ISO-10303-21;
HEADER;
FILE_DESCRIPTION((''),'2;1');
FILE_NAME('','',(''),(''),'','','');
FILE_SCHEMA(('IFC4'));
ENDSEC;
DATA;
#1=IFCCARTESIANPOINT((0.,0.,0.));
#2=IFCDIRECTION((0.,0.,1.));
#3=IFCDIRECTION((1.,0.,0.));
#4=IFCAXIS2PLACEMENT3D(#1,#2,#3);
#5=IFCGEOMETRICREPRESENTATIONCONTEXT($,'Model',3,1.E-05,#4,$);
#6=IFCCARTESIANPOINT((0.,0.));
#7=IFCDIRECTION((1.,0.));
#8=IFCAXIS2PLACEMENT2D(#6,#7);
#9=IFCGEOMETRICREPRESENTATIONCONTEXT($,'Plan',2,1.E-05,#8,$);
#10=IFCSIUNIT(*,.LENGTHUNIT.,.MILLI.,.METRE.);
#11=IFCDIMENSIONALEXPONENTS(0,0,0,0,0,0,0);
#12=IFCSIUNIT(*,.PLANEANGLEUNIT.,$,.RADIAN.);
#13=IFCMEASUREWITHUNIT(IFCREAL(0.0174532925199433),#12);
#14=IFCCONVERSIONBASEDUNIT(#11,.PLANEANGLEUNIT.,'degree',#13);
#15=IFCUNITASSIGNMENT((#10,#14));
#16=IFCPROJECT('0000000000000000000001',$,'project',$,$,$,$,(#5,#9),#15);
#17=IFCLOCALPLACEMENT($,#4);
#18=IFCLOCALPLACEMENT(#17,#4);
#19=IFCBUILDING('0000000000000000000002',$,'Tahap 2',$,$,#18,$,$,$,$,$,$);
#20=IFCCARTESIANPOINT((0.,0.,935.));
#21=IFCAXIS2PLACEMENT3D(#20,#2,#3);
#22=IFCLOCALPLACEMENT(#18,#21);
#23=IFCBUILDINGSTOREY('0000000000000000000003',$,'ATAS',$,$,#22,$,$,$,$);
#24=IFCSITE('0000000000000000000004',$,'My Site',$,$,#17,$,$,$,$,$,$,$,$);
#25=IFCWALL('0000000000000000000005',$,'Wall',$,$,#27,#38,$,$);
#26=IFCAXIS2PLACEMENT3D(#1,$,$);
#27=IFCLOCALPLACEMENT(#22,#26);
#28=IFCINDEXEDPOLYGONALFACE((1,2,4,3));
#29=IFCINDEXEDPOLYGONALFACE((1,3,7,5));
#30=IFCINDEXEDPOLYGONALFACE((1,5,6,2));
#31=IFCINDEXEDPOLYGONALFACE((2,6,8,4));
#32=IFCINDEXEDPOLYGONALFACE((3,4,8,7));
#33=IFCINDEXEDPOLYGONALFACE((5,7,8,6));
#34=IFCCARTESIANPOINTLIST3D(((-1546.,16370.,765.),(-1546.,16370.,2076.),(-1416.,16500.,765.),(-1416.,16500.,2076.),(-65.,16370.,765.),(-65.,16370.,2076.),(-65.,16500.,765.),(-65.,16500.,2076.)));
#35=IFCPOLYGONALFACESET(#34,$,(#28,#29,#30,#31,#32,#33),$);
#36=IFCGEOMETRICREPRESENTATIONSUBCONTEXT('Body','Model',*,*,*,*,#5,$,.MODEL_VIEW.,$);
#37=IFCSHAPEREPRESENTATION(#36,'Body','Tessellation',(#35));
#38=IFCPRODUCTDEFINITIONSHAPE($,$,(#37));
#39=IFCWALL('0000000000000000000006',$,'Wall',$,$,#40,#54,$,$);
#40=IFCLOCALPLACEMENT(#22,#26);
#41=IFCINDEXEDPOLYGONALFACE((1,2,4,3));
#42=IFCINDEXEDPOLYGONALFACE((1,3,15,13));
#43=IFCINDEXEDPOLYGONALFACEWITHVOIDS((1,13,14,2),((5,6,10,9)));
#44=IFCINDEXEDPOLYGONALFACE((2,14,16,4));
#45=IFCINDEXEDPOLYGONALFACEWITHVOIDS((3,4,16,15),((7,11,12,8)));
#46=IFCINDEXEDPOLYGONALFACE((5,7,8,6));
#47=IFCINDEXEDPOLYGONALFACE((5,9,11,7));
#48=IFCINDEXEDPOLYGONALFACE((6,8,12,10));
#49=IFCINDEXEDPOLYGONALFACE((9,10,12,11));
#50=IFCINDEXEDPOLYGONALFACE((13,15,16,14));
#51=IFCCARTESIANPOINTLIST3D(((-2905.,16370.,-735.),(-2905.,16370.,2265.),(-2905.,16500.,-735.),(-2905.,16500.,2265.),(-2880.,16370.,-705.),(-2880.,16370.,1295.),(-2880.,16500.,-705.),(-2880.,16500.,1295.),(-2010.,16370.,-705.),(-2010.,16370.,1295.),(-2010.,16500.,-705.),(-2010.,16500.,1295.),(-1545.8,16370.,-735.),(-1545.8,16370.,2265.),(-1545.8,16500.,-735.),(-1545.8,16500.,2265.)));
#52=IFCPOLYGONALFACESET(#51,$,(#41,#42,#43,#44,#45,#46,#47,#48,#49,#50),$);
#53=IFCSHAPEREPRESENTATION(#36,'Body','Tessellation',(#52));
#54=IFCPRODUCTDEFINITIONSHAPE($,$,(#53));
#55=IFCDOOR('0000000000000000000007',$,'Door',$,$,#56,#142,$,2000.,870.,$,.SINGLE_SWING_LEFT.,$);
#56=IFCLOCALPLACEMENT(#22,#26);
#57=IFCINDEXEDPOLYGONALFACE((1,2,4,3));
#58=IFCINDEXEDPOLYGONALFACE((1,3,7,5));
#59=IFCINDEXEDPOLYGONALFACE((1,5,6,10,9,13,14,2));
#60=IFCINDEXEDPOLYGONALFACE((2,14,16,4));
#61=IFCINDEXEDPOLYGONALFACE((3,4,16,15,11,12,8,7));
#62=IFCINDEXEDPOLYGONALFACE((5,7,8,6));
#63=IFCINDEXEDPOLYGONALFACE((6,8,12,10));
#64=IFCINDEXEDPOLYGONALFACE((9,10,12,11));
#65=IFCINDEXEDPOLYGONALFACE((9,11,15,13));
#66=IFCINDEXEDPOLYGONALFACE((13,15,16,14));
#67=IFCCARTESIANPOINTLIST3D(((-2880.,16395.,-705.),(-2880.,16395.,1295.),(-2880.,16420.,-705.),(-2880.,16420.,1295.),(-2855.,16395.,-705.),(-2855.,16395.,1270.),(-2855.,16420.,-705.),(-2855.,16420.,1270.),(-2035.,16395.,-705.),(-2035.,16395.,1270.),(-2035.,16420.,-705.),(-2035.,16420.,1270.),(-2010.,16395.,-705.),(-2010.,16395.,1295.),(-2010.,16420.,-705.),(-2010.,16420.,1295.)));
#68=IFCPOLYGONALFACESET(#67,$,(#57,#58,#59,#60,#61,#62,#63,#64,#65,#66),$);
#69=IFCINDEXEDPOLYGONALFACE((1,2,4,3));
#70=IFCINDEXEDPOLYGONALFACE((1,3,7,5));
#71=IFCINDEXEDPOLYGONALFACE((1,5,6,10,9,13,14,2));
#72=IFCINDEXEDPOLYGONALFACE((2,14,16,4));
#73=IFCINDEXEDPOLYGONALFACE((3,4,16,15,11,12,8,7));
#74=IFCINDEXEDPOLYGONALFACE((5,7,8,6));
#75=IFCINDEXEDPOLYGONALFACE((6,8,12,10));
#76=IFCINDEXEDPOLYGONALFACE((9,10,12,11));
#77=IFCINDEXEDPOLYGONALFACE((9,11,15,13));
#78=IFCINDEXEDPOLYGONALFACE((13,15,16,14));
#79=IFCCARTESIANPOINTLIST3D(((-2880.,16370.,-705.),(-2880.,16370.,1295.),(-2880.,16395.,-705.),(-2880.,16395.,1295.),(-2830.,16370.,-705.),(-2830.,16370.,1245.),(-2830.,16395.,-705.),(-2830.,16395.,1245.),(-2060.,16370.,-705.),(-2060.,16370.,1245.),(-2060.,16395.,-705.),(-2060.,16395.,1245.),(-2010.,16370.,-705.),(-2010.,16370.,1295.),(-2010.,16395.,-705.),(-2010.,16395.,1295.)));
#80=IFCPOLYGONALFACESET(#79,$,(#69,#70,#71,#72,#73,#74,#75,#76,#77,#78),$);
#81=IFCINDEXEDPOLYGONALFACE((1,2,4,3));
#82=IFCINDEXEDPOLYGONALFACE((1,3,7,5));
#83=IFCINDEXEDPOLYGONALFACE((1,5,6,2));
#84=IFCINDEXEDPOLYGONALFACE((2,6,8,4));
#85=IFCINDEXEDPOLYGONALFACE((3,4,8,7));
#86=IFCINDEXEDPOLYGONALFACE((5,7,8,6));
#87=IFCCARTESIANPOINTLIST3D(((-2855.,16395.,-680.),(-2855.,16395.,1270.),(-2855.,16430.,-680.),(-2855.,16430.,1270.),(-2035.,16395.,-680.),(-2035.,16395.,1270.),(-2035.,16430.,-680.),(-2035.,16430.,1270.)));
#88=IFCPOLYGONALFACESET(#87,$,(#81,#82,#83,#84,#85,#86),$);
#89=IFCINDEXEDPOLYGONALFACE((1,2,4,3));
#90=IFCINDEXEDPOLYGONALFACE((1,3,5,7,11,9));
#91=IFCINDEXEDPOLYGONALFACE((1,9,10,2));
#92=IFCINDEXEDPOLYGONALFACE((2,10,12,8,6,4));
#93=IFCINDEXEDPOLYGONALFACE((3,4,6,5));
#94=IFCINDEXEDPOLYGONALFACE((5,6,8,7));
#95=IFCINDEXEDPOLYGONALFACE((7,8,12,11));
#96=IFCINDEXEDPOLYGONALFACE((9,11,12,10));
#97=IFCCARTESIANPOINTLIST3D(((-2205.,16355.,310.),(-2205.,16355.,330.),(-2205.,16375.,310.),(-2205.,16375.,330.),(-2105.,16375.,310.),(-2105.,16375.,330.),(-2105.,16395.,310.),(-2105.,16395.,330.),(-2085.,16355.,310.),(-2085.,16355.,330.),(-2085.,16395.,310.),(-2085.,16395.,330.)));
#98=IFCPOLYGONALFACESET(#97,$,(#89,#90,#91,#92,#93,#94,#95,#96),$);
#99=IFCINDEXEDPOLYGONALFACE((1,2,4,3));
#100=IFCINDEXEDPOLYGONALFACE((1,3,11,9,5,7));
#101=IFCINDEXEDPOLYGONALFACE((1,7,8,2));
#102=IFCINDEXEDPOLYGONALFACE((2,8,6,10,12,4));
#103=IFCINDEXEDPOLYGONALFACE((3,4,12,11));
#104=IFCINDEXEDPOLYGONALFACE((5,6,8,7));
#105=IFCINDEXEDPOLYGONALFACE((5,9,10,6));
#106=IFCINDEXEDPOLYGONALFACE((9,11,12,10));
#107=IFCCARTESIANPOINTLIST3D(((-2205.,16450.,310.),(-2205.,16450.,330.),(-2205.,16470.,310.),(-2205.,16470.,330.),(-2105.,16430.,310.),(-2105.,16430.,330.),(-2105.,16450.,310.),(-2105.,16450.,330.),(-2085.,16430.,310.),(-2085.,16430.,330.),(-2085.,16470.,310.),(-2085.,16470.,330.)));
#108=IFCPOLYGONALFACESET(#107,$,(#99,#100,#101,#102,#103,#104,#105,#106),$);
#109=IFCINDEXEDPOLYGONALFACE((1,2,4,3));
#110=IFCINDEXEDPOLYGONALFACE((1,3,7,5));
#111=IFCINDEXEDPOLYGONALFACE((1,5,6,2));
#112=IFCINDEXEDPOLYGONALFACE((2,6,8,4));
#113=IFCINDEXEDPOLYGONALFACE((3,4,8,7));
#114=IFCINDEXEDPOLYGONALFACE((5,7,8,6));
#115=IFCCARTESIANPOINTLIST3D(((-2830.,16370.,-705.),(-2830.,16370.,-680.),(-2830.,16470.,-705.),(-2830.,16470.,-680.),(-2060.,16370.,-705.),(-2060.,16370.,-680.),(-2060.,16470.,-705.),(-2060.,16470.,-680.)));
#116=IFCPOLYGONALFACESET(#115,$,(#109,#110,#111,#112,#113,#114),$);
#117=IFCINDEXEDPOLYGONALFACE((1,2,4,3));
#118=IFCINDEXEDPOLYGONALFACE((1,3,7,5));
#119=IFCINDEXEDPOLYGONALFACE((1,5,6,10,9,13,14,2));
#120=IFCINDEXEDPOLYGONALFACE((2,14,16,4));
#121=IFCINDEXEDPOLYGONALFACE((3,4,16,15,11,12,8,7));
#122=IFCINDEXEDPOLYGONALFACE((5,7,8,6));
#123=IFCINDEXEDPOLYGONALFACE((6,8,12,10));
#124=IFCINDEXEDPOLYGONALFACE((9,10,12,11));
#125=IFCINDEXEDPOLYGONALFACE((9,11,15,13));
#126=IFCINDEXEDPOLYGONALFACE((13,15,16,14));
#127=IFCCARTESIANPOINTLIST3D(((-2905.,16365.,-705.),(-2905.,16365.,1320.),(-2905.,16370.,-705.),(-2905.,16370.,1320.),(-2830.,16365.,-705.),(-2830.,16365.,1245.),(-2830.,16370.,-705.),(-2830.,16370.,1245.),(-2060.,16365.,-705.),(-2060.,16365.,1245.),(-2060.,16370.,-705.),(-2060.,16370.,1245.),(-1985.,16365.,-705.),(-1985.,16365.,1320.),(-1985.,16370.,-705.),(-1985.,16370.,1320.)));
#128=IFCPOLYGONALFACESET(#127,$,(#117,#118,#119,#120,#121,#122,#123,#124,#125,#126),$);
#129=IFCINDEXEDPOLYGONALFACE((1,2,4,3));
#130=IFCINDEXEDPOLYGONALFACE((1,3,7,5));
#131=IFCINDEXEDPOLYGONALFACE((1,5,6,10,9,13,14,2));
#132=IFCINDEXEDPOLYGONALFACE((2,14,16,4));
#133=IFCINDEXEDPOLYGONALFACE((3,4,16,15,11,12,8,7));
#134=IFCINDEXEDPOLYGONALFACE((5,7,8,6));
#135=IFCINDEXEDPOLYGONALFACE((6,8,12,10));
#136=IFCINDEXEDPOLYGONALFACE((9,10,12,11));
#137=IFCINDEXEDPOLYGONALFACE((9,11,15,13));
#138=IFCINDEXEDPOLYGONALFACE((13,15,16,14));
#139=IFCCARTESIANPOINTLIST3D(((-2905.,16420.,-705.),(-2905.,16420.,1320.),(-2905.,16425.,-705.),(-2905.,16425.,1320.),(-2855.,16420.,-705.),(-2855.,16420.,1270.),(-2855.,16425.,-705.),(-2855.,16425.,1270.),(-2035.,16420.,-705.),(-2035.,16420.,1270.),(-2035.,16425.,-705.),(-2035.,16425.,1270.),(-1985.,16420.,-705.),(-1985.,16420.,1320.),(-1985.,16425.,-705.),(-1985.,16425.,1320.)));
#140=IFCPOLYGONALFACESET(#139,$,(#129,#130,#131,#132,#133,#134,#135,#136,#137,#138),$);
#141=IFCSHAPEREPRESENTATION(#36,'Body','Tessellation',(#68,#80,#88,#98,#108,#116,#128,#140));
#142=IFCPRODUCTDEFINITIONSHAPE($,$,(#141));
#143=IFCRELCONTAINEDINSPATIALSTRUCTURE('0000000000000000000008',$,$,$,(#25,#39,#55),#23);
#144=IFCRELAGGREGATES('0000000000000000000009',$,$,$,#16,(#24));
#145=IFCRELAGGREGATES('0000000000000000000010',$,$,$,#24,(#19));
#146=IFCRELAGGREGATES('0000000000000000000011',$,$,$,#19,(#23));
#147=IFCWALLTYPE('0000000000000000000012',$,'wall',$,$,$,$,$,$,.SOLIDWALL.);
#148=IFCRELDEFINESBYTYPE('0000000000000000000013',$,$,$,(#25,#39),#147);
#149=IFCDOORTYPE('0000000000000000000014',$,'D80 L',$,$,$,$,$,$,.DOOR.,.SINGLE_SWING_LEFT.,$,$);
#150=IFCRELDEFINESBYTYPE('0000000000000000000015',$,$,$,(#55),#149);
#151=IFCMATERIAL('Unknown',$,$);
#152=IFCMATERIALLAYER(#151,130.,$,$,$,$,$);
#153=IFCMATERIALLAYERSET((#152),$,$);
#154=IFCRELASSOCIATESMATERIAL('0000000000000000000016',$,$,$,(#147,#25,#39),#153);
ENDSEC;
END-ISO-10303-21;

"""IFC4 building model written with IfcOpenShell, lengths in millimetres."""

from ifc_helpers import new_model, entity, si_unit, converted_unit, frame, origin_with_axes, origin_2d_with_axis, place, context, subcontext, project, spatial, line, indexed_curve, outline, extrude, shape, source, transform, mapped, material, layer, layer_set, layer_usage, type_object, type_shapes, element, fill, save


model = new_model("IFC4")

# Units and contexts
model_context = context("Model", 3, precision=1e-05, world=origin_with_axes())
plan_context = context("Plan", 2, precision=1e-05, world=origin_2d_with_axis())
body_context_1 = subcontext(model_context, "Body", "Model", "MODEL_VIEW")
body_context_2 = subcontext(plan_context, "Body", "Plan", "PLAN_VIEW")
ifc_project = project(units=[si_unit("LENGTHUNIT", "METRE", prefix="MILLI"), converted_unit("PLANEANGLEUNIT", "degree", entity("IfcReal", 0.0174532925199433), si_unit("PLANEANGLEUNIT", "RADIAN"), dimensions=[0, 0, 0, 0, 0, 0, 0])], contexts=[model_context, plan_context])

# Site, building, storey
site_placement = place(None, origin_with_axes())
site = spatial("IfcSite", under=ifc_project, at=site_placement, Name="My Site")
building_placement = place(site_placement, origin_with_axes())
building = spatial("IfcBuilding", under=site, at=building_placement, Name="Tahap 2")
storey_placement = place(building_placement, frame((0.0, 0.0, 935.0), z_axis=(0.0, 0.0, 1.0), x_axis=(1.0, 0.0, 0.0)))
storey = spatial("IfcBuildingStorey", under=building, at=storey_placement, Name="ATAS")

# Wall
ifc_material_1 = material(Name="Unknown")
ifc_layer_1 = layer(ifc_material_1, 130.0)
ifc_layer_set_1 = layer_set([ifc_layer_1])
wall_type_1 = type_object("IfcWallType", Name="wall", PredefinedType="SOLIDWALL", material=ifc_layer_set_1)
ifc_layer_usage_1 = layer_usage(ifc_layer_set_1, "AXIS2", "POSITIVE", 0.0)
wall_1_placement = place(storey_placement, frame((-1546.0, 16370.0, 765.0), z_axis=(0.0, 0.0, 1.0), x_axis=(1.0, 0.0, 0.0)))
element("IfcWall", 1, at=wall_1_placement, inside=storey, type_object=wall_type_1, material=ifc_layer_usage_1, Name="Wall", context=body_context_1, shape_type="SweptSolid", body=[
    extrude(outline(indexed_curve([(0.0, 0.0), (130.0, 130.0), (1481.0, 130.0), (1481.0, 0.0)], segments=[line(1, 2, 3, 4, 1)])), origin_with_axes(), (0.0, 0.0, 1.0), 1311.0),
])

# Wall, opening, door
ifc_layer_usage_2 = layer_usage(ifc_layer_set_1, "AXIS2", "POSITIVE", 0.0)
wall_2_placement = place(storey_placement, frame((-2905.0, 16370.0, -735.0), z_axis=(0.0, 0.0, 1.0), x_axis=(1.0, 0.0, 0.0)))
wall_2 = element("IfcWall", 2, at=wall_2_placement, inside=storey, type_object=wall_type_1, material=ifc_layer_usage_2, Name="Wall", context=body_context_1, shape_type="SweptSolid", body=[
    extrude(outline(indexed_curve([(0.0, 0.0), (0.0, 130.0), (1359.2, 130.0), (1359.2, 0.0)], segments=[line(1, 2, 3, 4, 1)])), origin_with_axes(), (0.0, 0.0, 1.0), 3000.0),
])
shared_shape_1 = source(origin_with_axes(), body_context_1, "Body", "SweptSolid", [
    extrude(outline(indexed_curve([(0.0, 0.0), (870.0, 0.0), (870.0, 2000.0), (0.0, 2000.0)], segments=[line(1, 2, 3, 4, 1)])), frame((0.0, -600.0, 0.0), z_axis=(0.0, -1.0, 0.0), x_axis=(1.0, 0.0, 0.0)), (0.0, 0.0, -1.0), 1200.0),
])
opening_placement = place(wall_2_placement, frame((25.0, 0.0, 30.0), z_axis=(0.0, 0.0, 1.0), x_axis=(1.0, 0.0, 0.0)))
opening = element("IfcOpeningElement", 3, at=opening_placement, cuts=wall_2, PredefinedType="OPENING", context=body_context_1, shape_type="MappedRepresentation", body=[
    mapped(shared_shape_1, transform((0.0, 0.0, 0.0), x_axis=(1.0, 0.0, 0.0), y_axis=(0.0, 1.0, 0.0), z_axis=(0.0, 0.0, 1.0), scale=1.0)),
])
door_type = type_object("IfcDoorType", Name="D80 L", OperationType="SINGLE_SWING_LEFT", PredefinedType="DOOR")
shared_shape_2 = source(origin_with_axes(), body_context_1, "Body", "SweptSolid", [
    extrude(outline(indexed_curve([(0.0, 0.0), (0.0, 2000.0), (870.0, 2000.0), (870.0, 0.0), (845.0, 0.0), (845.0, 1975.0), (25.0, 1975.0), (25.0, 0.0)], segments=[line(1, 2, 3, 4, 5, 6, 7, 8, 1)])), frame((0.0, 25.0, 0.0), z_axis=(0.0, -1.0, 0.0), x_axis=(1.0, 0.0, 0.0)), (0.0, 0.0, -1.0), 25.0),
    extrude(outline(indexed_curve([(0.0, 0.0), (0.0, 2000.0), (870.0, 2000.0), (870.0, 0.0), (820.0, 0.0), (820.0, 1950.0), (50.0, 1950.0), (50.0, 0.0)], segments=[line(1, 2, 3, 4, 5, 6, 7, 8, 1)])), frame((0.0, 0.0, 0.0), z_axis=(0.0, -1.0, 0.0), x_axis=(1.0, 0.0, 0.0)), (0.0, 0.0, -1.0), 25.0),
    extrude(outline(indexed_curve([(0.0, 0.0), (820.0, 0.0), (820.0, 35.0), (0.0, 35.0)], segments=[line(1, 2, 3, 4, 1)])), frame((25.0, 25.0, 25.0), z_axis=(0.0, 0.0, 1.0), x_axis=(1.0, 0.0, 0.0)), (0.0, 0.0, 1.0), 1950.0),
    extrude(outline(indexed_curve([(0.0, 0.0), (0.0, -40.0), (-120.0, -40.0), (-120.0, -20.0), (-20.0, -20.0), (-20.0, 0.0)], segments=[line(1, 2, 3, 4, 5, 6, 1)])), frame((795.0, 25.0, 1015.0), z_axis=(0.0, 0.0, 1.0), x_axis=(1.0, 0.0, 0.0)), (0.0, 0.0, 1.0), 20.0),
    extrude(outline(indexed_curve([(0.0, 0.0), (0.0, 40.0), (-120.0, 40.0), (-120.0, 20.0), (-20.0, 20.0), (-20.0, 0.0)], segments=[line(1, 2, 3, 4, 5, 6, 1)])), frame((795.0, 60.0, 1015.0), z_axis=(0.0, 0.0, 1.0), x_axis=(1.0, 0.0, 0.0)), (0.0, 0.0, 1.0), 20.0),
    extrude(outline(indexed_curve([(0.0, 0.0), (770.0, 0.0), (770.0, 100.0), (0.0, 100.0)], segments=[line(1, 2, 3, 4, 1)])), frame((50.0, 0.0, 0.0), z_axis=(0.0, 0.0, 1.0), x_axis=(1.0, 0.0, 0.0)), (0.0, 0.0, 1.0), 25.0),
    extrude(outline(indexed_curve([(0.0, 0.0), (0.0, 2025.0), (920.0, 2025.0), (920.0, 0.0), (845.0, 0.0), (845.0, 1950.0), (75.0, 1950.0), (75.0, 0.0)], segments=[line(1, 2, 3, 4, 5, 6, 7, 8, 1)])), frame((-25.0, -5.0, 0.0), z_axis=(0.0, -1.0, 0.0), x_axis=(1.0, 0.0, 0.0)), (0.0, 0.0, -1.0), 5.0),
    extrude(outline(indexed_curve([(0.0, 0.0), (0.0, 2025.0), (920.0, 2025.0), (920.0, 0.0), (870.0, 0.0), (870.0, 1975.0), (50.0, 1975.0), (50.0, 0.0)], segments=[line(1, 2, 3, 4, 5, 6, 7, 8, 1)])), frame((-25.0, 50.0, 0.0), z_axis=(0.0, -1.0, 0.0), x_axis=(1.0, 0.0, 0.0)), (0.0, 0.0, -1.0), 5.0),
])
shared_shape_3 = source(origin_with_axes(), body_context_2, "Body", "Curve2D", [
    entity("IfcIndexedPolyCurve", entity("IfcCartesianPointList2D", [[0.0, 0.0], [0.0, 50.0], [25.0, 50.0], [25.0, 25.0], [50.0, 25.0], [50.0, 0.0]]), [entity("IfcLineIndex", [1, 2, 3, 4, 5, 6, 1])]),
    entity("IfcIndexedPolyCurve", entity("IfcCartesianPointList2D", [[870.0, 0.0], [870.0, 50.0], [845.0, 50.0], [845.0, 25.0], [820.0, 25.0], [820.0, 0.0]]), [entity("IfcLineIndex", [1, 2, 3, 4, 5, 6, 1])]),
    entity("IfcTrimmedCurve", entity("IfcEllipse", entity("IfcAxis2Placement2D", entity("IfcCartesianPoint", [60.0, 50.0]), entity("IfcDirection", [1.0, 0.0])), 785.0, 820.0), [entity("IfcCartesianPoint", [845.0, 50.0])], [entity("IfcCartesianPoint", [60.0, 870.0])], True, "CARTESIAN"),
    entity("IfcIndexedPolyCurve", entity("IfcCartesianPointList2D", [[25.0, 50.0], [60.0, 50.0], [60.0, 870.0], [25.0, 870.0]]), [entity("IfcLineIndex", [1, 2, 3, 4, 1])]),
])
type_shapes(door_type, [shared_shape_2, shared_shape_3])
door_placement = place(opening_placement, origin_with_axes())
door = element("IfcDoor", 4, at=door_placement, inside=storey, type_object=door_type, Name="Door", OperationType="SINGLE_SWING_LEFT", OverallHeight=2000.0, OverallWidth=870.0, shapes=[
    shape(body_context_1, "Body", "MappedRepresentation", [mapped(shared_shape_2, transform((0.0, 0.0, 0.0), x_axis=(1.0, 0.0, 0.0), y_axis=(0.0, 1.0, 0.0), z_axis=(0.0, 0.0, 1.0), scale=1.0))]),
    shape(body_context_2, "Body", "MappedRepresentation", [mapped(shared_shape_3, transform((0.0, 0.0, 0.0), x_axis=(1.0, 0.0, 0.0), y_axis=(0.0, 1.0, 0.0), z_axis=(0.0, 0.0, 1.0), scale=1.0))]),
])
fill(opening, door)

save(model, "model.ifc")
